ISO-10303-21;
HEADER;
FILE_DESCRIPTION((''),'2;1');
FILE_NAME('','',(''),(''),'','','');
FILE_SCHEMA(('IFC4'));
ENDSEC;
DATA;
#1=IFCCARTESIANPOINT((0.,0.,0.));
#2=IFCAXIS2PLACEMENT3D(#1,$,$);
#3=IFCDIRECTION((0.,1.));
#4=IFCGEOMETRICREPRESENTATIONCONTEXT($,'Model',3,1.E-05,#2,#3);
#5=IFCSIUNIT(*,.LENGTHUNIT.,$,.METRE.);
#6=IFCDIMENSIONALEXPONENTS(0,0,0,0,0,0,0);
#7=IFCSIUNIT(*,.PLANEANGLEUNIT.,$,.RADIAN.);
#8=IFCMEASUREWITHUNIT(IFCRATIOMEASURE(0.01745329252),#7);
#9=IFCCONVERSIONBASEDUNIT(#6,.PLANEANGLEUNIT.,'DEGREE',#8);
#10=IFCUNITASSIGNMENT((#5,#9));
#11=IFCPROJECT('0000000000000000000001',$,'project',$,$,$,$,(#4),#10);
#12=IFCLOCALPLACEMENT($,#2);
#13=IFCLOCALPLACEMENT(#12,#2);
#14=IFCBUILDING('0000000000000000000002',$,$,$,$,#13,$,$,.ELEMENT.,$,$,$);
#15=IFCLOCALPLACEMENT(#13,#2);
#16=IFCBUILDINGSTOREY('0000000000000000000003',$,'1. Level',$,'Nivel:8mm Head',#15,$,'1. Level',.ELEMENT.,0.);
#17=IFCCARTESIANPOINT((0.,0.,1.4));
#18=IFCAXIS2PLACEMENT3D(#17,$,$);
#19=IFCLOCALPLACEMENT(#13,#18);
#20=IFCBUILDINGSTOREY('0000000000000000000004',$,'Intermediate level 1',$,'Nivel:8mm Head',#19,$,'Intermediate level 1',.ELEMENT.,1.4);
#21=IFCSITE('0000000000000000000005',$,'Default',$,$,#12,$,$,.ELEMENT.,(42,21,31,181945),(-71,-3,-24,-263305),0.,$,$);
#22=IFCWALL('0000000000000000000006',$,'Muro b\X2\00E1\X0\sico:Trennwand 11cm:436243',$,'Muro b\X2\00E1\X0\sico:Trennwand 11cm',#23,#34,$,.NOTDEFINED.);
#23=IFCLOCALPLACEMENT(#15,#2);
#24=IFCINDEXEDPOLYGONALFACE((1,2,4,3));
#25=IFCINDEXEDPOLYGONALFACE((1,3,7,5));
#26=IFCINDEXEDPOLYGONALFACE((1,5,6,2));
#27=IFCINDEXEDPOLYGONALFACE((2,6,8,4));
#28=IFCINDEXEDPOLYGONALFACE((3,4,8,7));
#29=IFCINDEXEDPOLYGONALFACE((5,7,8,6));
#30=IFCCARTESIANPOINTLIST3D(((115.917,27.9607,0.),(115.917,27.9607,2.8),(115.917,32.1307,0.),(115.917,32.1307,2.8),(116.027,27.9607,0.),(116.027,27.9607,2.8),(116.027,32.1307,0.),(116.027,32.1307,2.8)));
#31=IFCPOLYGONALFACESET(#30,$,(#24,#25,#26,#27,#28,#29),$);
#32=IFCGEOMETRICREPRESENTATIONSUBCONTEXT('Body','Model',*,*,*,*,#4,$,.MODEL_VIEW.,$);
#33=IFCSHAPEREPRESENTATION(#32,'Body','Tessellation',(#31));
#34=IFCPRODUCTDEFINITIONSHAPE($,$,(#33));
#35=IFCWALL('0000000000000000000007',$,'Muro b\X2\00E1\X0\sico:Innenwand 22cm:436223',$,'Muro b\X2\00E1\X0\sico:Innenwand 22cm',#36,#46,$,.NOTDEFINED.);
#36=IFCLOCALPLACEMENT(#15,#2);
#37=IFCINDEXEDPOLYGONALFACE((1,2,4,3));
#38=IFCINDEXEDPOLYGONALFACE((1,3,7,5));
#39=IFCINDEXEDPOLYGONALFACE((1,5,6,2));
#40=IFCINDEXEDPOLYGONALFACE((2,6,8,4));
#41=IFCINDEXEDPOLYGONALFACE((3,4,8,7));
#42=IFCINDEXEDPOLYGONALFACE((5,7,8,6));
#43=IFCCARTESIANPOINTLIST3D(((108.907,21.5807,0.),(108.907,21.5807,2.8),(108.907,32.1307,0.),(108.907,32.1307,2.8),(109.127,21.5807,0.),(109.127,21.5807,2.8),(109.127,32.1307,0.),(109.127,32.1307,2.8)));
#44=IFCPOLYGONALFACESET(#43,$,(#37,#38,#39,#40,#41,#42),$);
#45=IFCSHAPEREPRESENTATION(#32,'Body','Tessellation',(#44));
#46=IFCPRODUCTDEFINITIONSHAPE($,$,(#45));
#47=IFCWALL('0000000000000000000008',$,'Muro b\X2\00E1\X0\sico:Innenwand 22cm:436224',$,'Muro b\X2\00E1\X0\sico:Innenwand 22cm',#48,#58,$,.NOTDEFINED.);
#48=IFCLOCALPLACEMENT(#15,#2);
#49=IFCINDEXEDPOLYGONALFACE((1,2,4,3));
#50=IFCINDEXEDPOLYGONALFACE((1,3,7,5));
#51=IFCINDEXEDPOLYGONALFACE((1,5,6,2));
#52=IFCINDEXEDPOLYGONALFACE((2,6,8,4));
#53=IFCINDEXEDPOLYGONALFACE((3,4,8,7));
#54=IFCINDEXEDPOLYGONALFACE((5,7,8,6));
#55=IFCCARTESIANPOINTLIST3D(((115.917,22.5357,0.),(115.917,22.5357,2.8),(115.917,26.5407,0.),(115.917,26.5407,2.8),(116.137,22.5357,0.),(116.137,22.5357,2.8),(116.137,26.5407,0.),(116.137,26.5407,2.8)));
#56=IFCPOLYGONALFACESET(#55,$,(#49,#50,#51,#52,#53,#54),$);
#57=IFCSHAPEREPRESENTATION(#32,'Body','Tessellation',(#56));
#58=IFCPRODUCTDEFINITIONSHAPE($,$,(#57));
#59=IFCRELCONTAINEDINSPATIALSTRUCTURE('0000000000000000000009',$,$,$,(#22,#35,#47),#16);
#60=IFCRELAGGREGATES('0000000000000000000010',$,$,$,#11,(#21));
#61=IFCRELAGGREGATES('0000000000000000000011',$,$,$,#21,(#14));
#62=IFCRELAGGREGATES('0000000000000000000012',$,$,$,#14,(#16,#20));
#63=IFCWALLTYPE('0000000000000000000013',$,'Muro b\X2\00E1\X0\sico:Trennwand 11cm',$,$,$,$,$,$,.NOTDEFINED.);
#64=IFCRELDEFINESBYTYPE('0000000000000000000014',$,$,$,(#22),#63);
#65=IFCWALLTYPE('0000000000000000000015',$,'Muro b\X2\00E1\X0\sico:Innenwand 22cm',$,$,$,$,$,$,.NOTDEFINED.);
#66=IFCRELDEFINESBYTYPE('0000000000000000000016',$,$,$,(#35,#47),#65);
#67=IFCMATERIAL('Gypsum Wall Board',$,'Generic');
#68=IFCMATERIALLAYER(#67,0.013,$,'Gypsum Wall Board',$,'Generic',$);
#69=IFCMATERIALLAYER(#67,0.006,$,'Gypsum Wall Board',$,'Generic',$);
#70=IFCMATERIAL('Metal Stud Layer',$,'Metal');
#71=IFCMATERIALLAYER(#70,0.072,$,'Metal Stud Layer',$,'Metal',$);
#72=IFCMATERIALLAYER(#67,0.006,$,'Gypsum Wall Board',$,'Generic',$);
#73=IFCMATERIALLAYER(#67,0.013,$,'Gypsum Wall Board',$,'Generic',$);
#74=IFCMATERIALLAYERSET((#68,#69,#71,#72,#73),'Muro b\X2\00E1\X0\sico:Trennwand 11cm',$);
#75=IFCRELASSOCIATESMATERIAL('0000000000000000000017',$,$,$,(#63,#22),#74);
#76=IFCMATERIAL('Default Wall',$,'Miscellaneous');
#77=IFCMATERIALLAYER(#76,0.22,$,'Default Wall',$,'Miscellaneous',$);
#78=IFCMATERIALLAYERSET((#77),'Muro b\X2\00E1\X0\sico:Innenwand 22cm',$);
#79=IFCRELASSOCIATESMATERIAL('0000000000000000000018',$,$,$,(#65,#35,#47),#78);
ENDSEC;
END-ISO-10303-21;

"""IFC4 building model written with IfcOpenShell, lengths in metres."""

from ifc_helpers import new_model, entity, si_unit, converted_unit, direction, frame, frame_2d, origin, place, context, subcontext, project, spatial, rectangle, extrude, material, layer, layer_set, layer_usage, type_object, element, save


model = new_model("IFC4")

# Units and contexts
model_context = context("Model", 3, precision=1e-05, world=origin(), true_north=direction((0.0, 1.0)))
body_context = subcontext(model_context, "Body", "Model", "MODEL_VIEW")
ifc_project = project(units=[si_unit("LENGTHUNIT", "METRE"), converted_unit("PLANEANGLEUNIT", "DEGREE", entity("IfcRatioMeasure", 0.01745329252), si_unit("PLANEANGLEUNIT", "RADIAN"), dimensions=[0, 0, 0, 0, 0, 0, 0])], contexts=[model_context])

# Site, building, storey
site_placement = place(None, origin())
site = spatial("IfcSite", under=ifc_project, at=site_placement, Name="Default", CompositionType="ELEMENT", RefLatitude=(42, 21, 31, 181945), RefLongitude=(-71, -3, -24, -263305), RefElevation=0.0)
building_placement = place(site_placement, origin())
building = spatial("IfcBuilding", under=site, at=building_placement, CompositionType="ELEMENT")
storey_1_placement = place(building_placement, origin())
storey_1 = spatial("IfcBuildingStorey", under=building, at=storey_1_placement, Name="1. Level", ObjectType="Nivel:8mm Head", LongName="1. Level", CompositionType="ELEMENT", Elevation=0.0)

# Shared definitions
storey_2_placement = place(building_placement, frame((0.0, 0.0, 1.4)))
storey_2 = spatial("IfcBuildingStorey", under=building, at=storey_2_placement, Name="Intermediate level 1", ObjectType="Nivel:8mm Head", LongName="Intermediate level 1", CompositionType="ELEMENT", Elevation=1.4)

# Shared definitions
ifc_material_1 = material(Name="Gypsum Wall Board", Category="Generic")
ifc_layer_1 = layer(ifc_material_1, 0.013, Name="Gypsum Wall Board", Category="Generic")
ifc_layer_2 = layer(ifc_material_1, 0.006, Name="Gypsum Wall Board", Category="Generic")
ifc_material_2 = material(Name="Metal Stud Layer", Category="Metal")
ifc_layer_3 = layer(ifc_material_2, 0.072, Name="Metal Stud Layer", Category="Metal")
ifc_layer_4 = layer(ifc_material_1, 0.006, Name="Gypsum Wall Board", Category="Generic")
ifc_layer_5 = layer(ifc_material_1, 0.013, Name="Gypsum Wall Board", Category="Generic")
ifc_layer_set_1 = layer_set([ifc_layer_1, ifc_layer_2, ifc_layer_3, ifc_layer_4, ifc_layer_5], Name="Muro básico:Trennwand 11cm")
wall_type_1 = type_object("IfcWallType", Name="Muro básico:Trennwand 11cm", PredefinedType="NOTDEFINED", material=ifc_layer_set_1)

# Walls
ifc_layer_usage_1 = layer_usage(ifc_layer_set_1, "AXIS2", "NEGATIVE", 0.055)
wall_1_placement = place(storey_1_placement, frame((115.972, 27.9607, 0.0), z_axis=(0.0, 0.0, 1.0), x_axis=(0.0, 1.0, 0.0)))
element("IfcWall", 1, at=wall_1_placement, inside=storey_1, type_object=wall_type_1, material=ifc_layer_usage_1, Name="Muro básico:Trennwand 11cm:436243", ObjectType="Muro básico:Trennwand 11cm", PredefinedType="NOTDEFINED", context=body_context, shape_type="SweptSolid", body=[
    extrude(rectangle(XDim=4.17, YDim=0.11, at=frame_2d((2.085, 0.0), x_axis=(-1.0, 0.0))), origin(), (0.0, 0.0, 1.0), 2.8),
])
ifc_material_3 = material(Name="Default Wall", Category="Miscellaneous")
ifc_layer_6 = layer(ifc_material_3, 0.22, Name="Default Wall", Category="Miscellaneous")
ifc_layer_set_2 = layer_set([ifc_layer_6], Name="Muro básico:Innenwand 22cm")
ifc_layer_usage_2 = layer_usage(ifc_layer_set_2, "AXIS2", "NEGATIVE", 0.11)
wall_type_2 = type_object("IfcWallType", Name="Muro básico:Innenwand 22cm", PredefinedType="NOTDEFINED", material=ifc_layer_set_2)
wall_2_placement = place(storey_1_placement, frame((109.017, 21.5807, 0.0), z_axis=(0.0, 0.0, 1.0), x_axis=(0.0, 1.0, 0.0)))
element("IfcWall", 2, at=wall_2_placement, inside=storey_1, type_object=wall_type_2, material=ifc_layer_usage_2, Name="Muro básico:Innenwand 22cm:436223", ObjectType="Muro básico:Innenwand 22cm", PredefinedType="NOTDEFINED", context=body_context, shape_type="SweptSolid", body=[
    extrude(rectangle(XDim=10.55, YDim=0.22, at=frame_2d((5.275, 0.0), x_axis=(-1.0, 0.0))), origin(), (0.0, 0.0, 1.0), 2.8),
])
ifc_layer_usage_3 = layer_usage(ifc_layer_set_2, "AXIS2", "NEGATIVE", 0.11)
wall_3_placement = place(storey_1_placement, frame((116.027, 22.5357, 0.0), z_axis=(0.0, 0.0, 1.0), x_axis=(0.0, 1.0, 0.0)))
element("IfcWall", 3, at=wall_3_placement, inside=storey_1, type_object=wall_type_2, material=ifc_layer_usage_3, Name="Muro básico:Innenwand 22cm:436224", ObjectType="Muro básico:Innenwand 22cm", PredefinedType="NOTDEFINED", context=body_context, shape_type="SweptSolid", body=[
    extrude(rectangle(XDim=4.005, YDim=0.22, at=frame_2d((2.0025, 0.0), x_axis=(-1.0, 0.0))), origin(), (0.0, 0.0, 1.0), 2.8),
])

save(model, "model.ifc")
